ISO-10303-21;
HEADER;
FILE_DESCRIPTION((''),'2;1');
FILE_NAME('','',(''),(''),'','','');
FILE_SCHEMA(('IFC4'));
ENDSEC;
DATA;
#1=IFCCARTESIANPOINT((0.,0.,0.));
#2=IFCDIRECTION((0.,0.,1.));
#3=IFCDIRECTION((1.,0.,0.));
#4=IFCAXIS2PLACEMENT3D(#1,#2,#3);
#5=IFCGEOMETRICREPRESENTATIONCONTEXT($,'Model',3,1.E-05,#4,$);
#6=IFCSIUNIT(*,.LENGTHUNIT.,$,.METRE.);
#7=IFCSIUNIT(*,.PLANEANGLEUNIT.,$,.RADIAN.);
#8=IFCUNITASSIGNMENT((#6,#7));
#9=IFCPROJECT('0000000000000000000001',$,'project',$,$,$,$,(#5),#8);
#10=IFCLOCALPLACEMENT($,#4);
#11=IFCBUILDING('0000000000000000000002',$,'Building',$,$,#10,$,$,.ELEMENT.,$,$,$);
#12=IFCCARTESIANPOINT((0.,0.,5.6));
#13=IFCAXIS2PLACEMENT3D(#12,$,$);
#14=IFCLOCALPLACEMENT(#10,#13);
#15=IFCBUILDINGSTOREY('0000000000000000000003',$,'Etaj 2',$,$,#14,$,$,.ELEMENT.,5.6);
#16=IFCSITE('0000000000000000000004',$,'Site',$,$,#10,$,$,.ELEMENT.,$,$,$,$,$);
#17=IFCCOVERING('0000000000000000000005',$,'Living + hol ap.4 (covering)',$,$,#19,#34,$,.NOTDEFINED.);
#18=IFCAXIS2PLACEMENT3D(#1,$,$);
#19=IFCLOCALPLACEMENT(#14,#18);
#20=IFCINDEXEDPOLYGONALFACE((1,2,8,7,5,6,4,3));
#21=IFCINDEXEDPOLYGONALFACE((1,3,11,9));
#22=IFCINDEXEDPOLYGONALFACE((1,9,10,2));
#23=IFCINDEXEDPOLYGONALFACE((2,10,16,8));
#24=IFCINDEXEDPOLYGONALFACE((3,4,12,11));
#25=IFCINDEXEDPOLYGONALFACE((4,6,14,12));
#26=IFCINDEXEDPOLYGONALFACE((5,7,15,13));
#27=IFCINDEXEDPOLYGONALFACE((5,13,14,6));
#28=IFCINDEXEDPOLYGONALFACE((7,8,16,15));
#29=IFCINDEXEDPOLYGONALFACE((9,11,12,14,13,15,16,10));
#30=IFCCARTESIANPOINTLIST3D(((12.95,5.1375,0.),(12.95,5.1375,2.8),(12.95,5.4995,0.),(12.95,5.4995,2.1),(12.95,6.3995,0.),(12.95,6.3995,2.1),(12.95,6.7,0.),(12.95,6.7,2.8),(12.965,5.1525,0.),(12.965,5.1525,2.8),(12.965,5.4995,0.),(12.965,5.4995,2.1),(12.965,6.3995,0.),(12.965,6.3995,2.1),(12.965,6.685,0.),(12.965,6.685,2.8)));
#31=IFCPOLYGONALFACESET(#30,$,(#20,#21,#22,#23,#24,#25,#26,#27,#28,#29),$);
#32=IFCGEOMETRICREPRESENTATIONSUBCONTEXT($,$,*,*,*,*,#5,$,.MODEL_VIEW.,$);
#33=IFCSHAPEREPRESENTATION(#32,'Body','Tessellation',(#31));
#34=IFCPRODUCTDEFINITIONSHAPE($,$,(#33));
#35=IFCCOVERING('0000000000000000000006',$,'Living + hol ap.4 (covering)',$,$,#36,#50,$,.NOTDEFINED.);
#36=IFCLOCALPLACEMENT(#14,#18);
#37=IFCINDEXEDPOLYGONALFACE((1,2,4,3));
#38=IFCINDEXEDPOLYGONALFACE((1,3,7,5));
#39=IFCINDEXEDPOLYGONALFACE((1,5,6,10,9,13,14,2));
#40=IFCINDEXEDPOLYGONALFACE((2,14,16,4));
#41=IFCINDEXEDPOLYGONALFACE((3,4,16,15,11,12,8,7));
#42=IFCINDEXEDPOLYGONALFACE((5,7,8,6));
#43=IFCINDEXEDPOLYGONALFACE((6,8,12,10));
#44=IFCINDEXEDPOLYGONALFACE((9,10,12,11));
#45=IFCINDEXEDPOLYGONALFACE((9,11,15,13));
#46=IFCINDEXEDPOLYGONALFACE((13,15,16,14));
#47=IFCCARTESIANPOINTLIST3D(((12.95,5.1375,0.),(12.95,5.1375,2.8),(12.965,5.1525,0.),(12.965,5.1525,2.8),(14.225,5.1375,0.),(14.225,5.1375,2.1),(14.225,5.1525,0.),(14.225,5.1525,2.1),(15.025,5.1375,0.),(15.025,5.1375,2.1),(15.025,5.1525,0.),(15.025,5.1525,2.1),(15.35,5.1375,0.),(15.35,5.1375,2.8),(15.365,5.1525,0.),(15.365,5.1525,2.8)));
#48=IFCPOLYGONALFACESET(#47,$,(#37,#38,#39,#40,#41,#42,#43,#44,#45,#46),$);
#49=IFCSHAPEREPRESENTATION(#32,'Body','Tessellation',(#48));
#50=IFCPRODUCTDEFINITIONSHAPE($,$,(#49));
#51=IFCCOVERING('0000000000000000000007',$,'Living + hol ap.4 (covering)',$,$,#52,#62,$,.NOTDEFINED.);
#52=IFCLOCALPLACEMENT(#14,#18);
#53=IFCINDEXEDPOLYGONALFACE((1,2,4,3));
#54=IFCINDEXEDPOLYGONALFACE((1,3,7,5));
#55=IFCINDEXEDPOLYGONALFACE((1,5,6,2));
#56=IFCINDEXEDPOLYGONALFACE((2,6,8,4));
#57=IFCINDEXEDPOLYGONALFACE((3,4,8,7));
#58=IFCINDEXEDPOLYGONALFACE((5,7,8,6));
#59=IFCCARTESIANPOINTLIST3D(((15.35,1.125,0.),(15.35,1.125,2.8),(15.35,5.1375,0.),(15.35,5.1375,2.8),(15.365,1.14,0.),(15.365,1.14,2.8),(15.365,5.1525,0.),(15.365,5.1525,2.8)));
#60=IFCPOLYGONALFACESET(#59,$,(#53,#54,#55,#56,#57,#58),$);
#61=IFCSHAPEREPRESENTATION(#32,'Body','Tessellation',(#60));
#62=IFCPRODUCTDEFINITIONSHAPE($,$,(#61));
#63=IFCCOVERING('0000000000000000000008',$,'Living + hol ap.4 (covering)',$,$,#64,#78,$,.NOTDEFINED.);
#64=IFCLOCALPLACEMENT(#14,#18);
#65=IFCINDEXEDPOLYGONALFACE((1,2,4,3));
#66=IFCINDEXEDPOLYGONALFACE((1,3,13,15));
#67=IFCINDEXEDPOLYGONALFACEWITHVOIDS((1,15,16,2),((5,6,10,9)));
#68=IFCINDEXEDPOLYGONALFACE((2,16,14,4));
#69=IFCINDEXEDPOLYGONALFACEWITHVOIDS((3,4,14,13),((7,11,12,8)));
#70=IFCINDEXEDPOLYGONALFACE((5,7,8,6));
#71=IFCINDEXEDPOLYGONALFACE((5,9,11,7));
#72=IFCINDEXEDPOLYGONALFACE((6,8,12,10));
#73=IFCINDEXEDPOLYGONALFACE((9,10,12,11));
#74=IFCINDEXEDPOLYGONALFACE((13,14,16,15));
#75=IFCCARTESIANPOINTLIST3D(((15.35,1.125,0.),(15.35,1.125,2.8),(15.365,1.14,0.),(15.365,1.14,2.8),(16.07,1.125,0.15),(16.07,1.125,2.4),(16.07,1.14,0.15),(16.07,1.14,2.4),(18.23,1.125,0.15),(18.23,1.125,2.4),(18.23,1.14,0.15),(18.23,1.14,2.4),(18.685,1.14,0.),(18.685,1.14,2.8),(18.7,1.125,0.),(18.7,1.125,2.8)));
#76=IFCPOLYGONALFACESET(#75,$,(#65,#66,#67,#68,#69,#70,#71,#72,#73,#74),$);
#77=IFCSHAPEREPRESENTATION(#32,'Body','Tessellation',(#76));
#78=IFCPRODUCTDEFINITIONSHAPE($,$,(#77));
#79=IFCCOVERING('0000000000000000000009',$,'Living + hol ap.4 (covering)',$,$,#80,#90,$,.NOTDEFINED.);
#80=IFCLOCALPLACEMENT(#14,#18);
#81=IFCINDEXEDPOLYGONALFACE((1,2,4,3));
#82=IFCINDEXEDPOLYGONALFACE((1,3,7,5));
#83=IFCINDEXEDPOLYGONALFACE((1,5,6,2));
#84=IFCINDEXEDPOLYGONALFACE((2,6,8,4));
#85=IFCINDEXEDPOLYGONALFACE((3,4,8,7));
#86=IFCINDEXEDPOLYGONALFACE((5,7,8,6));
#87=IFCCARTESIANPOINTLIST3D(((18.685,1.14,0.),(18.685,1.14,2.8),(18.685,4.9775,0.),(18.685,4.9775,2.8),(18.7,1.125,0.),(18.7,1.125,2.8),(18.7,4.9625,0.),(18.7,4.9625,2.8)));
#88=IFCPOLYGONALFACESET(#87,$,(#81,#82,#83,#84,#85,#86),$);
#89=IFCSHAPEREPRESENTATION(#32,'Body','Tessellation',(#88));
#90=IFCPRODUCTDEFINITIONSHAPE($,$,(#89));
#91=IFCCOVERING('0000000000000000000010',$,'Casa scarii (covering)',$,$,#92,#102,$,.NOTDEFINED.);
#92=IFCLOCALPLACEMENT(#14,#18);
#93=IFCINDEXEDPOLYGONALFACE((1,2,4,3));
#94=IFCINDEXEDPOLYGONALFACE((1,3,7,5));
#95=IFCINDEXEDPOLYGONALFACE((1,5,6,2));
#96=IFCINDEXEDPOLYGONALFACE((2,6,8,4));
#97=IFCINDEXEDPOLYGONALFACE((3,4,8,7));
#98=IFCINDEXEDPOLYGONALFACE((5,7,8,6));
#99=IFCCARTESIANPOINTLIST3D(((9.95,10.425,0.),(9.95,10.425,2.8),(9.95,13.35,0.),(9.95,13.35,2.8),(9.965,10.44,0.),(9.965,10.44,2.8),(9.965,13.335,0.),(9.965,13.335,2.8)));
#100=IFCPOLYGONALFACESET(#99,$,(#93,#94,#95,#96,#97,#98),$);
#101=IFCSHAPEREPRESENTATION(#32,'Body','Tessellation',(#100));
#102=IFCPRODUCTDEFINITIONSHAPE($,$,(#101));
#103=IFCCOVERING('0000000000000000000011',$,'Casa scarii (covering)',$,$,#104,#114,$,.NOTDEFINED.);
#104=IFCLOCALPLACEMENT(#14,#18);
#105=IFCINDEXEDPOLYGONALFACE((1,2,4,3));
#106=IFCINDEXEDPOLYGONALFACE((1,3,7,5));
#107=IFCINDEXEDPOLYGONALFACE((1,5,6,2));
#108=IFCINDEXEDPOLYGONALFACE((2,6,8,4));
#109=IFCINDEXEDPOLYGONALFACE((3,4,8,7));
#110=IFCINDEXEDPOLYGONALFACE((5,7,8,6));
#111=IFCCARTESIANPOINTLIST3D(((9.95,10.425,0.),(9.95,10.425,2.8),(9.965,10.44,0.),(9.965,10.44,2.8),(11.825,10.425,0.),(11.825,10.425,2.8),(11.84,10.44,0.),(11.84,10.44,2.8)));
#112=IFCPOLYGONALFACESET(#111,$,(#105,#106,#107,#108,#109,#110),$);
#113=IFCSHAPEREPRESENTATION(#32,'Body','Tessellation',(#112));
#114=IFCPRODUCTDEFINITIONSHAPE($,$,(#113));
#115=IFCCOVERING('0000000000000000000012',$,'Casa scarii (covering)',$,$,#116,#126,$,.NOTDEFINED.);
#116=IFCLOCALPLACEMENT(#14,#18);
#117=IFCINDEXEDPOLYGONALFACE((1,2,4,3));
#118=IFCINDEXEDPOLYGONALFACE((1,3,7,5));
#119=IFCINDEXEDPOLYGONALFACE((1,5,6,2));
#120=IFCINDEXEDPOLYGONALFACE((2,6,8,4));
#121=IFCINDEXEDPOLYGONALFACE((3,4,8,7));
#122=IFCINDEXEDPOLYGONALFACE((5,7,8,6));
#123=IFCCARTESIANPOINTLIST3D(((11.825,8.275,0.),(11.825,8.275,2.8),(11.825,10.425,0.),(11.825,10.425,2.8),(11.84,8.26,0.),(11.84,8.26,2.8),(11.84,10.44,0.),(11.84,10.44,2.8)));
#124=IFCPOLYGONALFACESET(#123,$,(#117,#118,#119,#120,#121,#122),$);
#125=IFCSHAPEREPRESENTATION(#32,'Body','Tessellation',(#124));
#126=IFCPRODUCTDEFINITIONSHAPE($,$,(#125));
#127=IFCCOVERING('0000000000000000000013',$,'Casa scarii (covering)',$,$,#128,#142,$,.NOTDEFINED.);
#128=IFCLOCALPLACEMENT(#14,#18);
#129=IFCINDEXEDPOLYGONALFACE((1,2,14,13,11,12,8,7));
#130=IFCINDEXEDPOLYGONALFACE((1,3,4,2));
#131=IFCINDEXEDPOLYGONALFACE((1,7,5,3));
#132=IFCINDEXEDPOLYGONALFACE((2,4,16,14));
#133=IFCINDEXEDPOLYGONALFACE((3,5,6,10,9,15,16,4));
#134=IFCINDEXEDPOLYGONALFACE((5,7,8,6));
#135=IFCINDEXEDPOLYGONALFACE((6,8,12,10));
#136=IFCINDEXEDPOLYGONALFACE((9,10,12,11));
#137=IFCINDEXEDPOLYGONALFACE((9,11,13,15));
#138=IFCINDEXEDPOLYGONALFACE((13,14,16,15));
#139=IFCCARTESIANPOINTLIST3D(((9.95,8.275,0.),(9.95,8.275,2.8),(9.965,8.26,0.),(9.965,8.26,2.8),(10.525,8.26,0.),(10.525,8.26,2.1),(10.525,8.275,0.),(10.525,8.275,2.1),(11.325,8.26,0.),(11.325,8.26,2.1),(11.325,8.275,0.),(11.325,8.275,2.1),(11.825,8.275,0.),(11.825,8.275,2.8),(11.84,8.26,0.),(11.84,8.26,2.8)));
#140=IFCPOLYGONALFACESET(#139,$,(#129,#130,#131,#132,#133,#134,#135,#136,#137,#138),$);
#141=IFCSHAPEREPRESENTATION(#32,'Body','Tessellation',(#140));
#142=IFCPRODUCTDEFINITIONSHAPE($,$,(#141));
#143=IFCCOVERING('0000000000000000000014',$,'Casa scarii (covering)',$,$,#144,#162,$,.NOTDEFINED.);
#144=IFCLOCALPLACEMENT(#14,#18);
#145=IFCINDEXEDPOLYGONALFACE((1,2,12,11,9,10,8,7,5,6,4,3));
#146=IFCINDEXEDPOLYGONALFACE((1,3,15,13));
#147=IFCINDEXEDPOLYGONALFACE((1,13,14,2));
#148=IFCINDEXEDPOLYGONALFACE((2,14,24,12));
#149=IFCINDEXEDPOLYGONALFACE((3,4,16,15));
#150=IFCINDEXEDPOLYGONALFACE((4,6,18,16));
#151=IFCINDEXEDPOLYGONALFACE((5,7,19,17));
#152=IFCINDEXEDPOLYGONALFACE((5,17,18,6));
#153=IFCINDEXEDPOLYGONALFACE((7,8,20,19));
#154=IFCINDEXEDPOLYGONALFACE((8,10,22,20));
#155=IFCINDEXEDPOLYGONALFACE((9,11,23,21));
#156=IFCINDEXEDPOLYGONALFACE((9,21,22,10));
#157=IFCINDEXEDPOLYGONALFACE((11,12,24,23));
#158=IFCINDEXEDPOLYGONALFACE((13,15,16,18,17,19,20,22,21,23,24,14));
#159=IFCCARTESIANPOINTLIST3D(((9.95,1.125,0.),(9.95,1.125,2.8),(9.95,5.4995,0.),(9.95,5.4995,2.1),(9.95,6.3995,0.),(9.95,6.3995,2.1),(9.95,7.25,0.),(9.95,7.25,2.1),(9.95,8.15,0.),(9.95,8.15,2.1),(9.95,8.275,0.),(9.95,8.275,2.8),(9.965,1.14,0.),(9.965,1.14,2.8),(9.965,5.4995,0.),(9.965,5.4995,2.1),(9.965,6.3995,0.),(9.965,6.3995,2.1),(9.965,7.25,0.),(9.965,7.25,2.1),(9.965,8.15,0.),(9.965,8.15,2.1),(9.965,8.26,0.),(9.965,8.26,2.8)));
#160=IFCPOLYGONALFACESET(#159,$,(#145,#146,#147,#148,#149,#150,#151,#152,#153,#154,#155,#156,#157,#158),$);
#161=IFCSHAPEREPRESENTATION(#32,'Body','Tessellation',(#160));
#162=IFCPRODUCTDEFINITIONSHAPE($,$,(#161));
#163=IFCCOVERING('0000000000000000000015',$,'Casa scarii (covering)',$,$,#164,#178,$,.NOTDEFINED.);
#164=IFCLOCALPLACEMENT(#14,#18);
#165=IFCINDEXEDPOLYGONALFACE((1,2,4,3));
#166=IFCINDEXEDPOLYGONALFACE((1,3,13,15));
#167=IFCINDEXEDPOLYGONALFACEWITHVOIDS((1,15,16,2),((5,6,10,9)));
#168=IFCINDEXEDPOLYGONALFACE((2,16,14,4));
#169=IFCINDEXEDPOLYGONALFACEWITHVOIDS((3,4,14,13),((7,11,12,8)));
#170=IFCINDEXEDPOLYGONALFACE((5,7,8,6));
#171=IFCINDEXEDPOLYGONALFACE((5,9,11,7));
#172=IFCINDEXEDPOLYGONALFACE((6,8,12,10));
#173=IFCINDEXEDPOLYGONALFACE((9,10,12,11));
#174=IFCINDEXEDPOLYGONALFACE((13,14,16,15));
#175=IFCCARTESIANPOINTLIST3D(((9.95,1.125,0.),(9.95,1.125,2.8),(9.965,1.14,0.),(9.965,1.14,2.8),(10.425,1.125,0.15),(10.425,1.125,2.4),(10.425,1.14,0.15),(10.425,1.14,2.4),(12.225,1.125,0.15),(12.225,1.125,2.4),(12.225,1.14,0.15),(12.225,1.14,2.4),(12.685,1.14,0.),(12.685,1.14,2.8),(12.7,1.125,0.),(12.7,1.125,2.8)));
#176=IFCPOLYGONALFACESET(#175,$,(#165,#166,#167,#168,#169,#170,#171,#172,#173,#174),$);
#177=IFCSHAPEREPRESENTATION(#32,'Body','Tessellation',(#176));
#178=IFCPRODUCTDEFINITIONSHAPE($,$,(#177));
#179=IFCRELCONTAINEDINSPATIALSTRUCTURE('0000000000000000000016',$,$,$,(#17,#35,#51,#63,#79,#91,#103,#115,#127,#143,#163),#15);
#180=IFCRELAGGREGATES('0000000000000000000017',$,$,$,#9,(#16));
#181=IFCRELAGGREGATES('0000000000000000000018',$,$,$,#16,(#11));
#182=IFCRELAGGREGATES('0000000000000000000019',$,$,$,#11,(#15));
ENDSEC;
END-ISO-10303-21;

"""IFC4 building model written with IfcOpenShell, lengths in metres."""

from ifc_helpers import new_model, si_unit, frame, origin, origin_with_axes, origin_2d, place, context, subcontext, project, spatial, polyline, rectangle, outline, extrude, element, save


model = new_model("IFC4")

# Units and contexts
model_context = context("Model", 3, precision=1e-05, world=origin_with_axes())
sub_context = subcontext(model_context, None, None, "MODEL_VIEW")
ifc_project = project(units=[si_unit("LENGTHUNIT", "METRE"), si_unit("PLANEANGLEUNIT", "RADIAN")], contexts=[model_context])

# Site, building, storey
placement = place(None, origin_with_axes())
site = spatial("IfcSite", under=ifc_project, at=placement, Name="Site", CompositionType="ELEMENT")
building = spatial("IfcBuilding", under=site, at=placement, Name="Building", CompositionType="ELEMENT")
storey_placement = place(placement, frame((0.0, 0.0, 5.6)))
storey = spatial("IfcBuildingStorey", under=building, at=storey_placement, Name="Etaj 2", CompositionType="ELEMENT", Elevation=5.6)

# Coverings, openings
covering_1_placement = place(storey_placement, origin_with_axes())
covering_1 = element("IfcCovering", 1, at=covering_1_placement, inside=storey, Name="Living + hol ap.4 (covering)", PredefinedType="NOTDEFINED", context=sub_context, shape_type="SweptSolid", body=[
    extrude(outline(polyline([(12.95, 6.7), (12.95, 5.1375), (12.965, 5.1525), (12.965, 6.685), (12.95, 6.7)])), origin(), (0.0, 0.0, 1.0), 2.8),
])
opening_1_placement = place(covering_1_placement, frame((12.635, 5.9495, 0.0), z_axis=(1.0, 0.0, 0.0), x_axis=(0.0, 1.0, 0.0)))
element("IfcOpeningElement", 2, at=opening_1_placement, cuts=covering_1, PredefinedType="OPENING", context=sub_context, shape_type="SweptSolid", body=[
    extrude(rectangle(XDim=0.9, YDim=2.1, at=origin_2d()), frame((0.0, 1.05, 0.0)), (0.0, 0.0, 1.0), 0.38),
])
covering_2_placement = place(storey_placement, origin_with_axes())
covering_2 = element("IfcCovering", 3, at=covering_2_placement, inside=storey, Name="Living + hol ap.4 (covering)", PredefinedType="NOTDEFINED", context=sub_context, shape_type="SweptSolid", body=[
    extrude(outline(polyline([(12.95, 5.1375), (15.35, 5.1375), (15.365, 5.1525), (12.965, 5.1525), (12.95, 5.1375)])), origin(), (0.0, 0.0, 1.0), 2.8),
])
opening_2_placement = place(covering_2_placement, frame((14.625, 5.2025, 0.0), z_axis=(0.0, -1.0, 0.0), x_axis=(1.0, 0.0, 0.0)))
element("IfcOpeningElement", 4, at=opening_2_placement, cuts=covering_2, PredefinedType="OPENING", context=sub_context, shape_type="SweptSolid", body=[
    extrude(rectangle(XDim=0.8, YDim=2.1, at=origin_2d()), frame((0.0, 1.05, 0.0)), (0.0, 0.0, 1.0), 0.38),
])

# Covering
covering_3_placement = place(storey_placement, origin_with_axes())
element("IfcCovering", 5, at=covering_3_placement, inside=storey, Name="Living + hol ap.4 (covering)", PredefinedType="NOTDEFINED", context=sub_context, shape_type="SweptSolid", body=[
    extrude(outline(polyline([(15.35, 5.1375), (15.35, 1.125), (15.365, 1.14), (15.365, 5.1525), (15.35, 5.1375)])), origin(), (0.0, 0.0, 1.0), 2.8),
])

# Covering, opening
covering_4_placement = place(storey_placement, origin_with_axes())
covering_4 = element("IfcCovering", 6, at=covering_4_placement, inside=storey, Name="Living + hol ap.4 (covering)", PredefinedType="NOTDEFINED", context=sub_context, shape_type="SweptSolid", body=[
    extrude(outline(polyline([(15.35, 1.125), (18.7, 1.125), (18.685, 1.14), (15.365, 1.14), (15.35, 1.125)])), origin(), (0.0, 0.0, 1.0), 2.8),
])
opening_3_placement = place(covering_4_placement, frame((17.15, 1.19, 0.15), z_axis=(0.0, -1.0, 0.0), x_axis=(1.0, 0.0, 0.0)))
element("IfcOpeningElement", 7, at=opening_3_placement, cuts=covering_4, PredefinedType="OPENING", context=sub_context, shape_type="SweptSolid", body=[
    extrude(rectangle(XDim=2.16, YDim=2.25, at=origin_2d()), frame((0.0, 1.125, 0.0)), (0.0, 0.0, 1.0), 0.38),
])

# Coverings
covering_5_placement = place(storey_placement, origin_with_axes())
element("IfcCovering", 8, at=covering_5_placement, inside=storey, Name="Living + hol ap.4 (covering)", PredefinedType="NOTDEFINED", context=sub_context, shape_type="SweptSolid", body=[
    extrude(outline(polyline([(18.7, 1.125), (18.7, 4.9625), (18.685, 4.9775), (18.685, 1.14), (18.7, 1.125)])), origin(), (0.0, 0.0, 1.0), 2.8),
])
covering_6_placement = place(storey_placement, origin_with_axes())
element("IfcCovering", 9, at=covering_6_placement, inside=storey, Name="Casa scarii (covering)", PredefinedType="NOTDEFINED", context=sub_context, shape_type="SweptSolid", body=[
    extrude(outline(polyline([(9.95, 13.35), (9.95, 10.425), (9.965, 10.44), (9.965, 13.335), (9.95, 13.35)])), origin(), (0.0, 0.0, 1.0), 2.8),
])
covering_7_placement = place(storey_placement, origin_with_axes())
element("IfcCovering", 10, at=covering_7_placement, inside=storey, Name="Casa scarii (covering)", PredefinedType="NOTDEFINED", context=sub_context, shape_type="SweptSolid", body=[
    extrude(outline(polyline([(9.95, 10.425), (11.825, 10.425), (11.84, 10.44), (9.965, 10.44), (9.95, 10.425)])), origin(), (0.0, 0.0, 1.0), 2.8),
])
covering_8_placement = place(storey_placement, origin_with_axes())
element("IfcCovering", 11, at=covering_8_placement, inside=storey, Name="Casa scarii (covering)", PredefinedType="NOTDEFINED", context=sub_context, shape_type="SweptSolid", body=[
    extrude(outline(polyline([(11.825, 10.425), (11.825, 8.275), (11.84, 8.26), (11.84, 10.44), (11.825, 10.425)])), origin(), (0.0, 0.0, 1.0), 2.8),
])

# Covering, opening
covering_9_placement = place(storey_placement, origin_with_axes())
covering_9 = element("IfcCovering", 12, at=covering_9_placement, inside=storey, Name="Casa scarii (covering)", PredefinedType="NOTDEFINED", context=sub_context, shape_type="SweptSolid", body=[
    extrude(outline(polyline([(11.825, 8.275), (9.95, 8.275), (9.965, 8.26), (11.84, 8.26), (11.825, 8.275)])), origin(), (0.0, 0.0, 1.0), 2.8),
])
opening_4_placement = place(covering_9_placement, frame((10.925, 8.59, 0.0), z_axis=(0.0, -1.0, 0.0), x_axis=(1.0, 0.0, 0.0)))
element("IfcOpeningElement", 13, at=opening_4_placement, cuts=covering_9, PredefinedType="OPENING", context=sub_context, shape_type="SweptSolid", body=[
    extrude(rectangle(XDim=0.8, YDim=2.1, at=origin_2d()), frame((0.0, 1.05, 0.0)), (0.0, 0.0, 1.0), 0.38),
])

# Covering, openings
covering_10_placement = place(storey_placement, origin_with_axes())
covering_10 = element("IfcCovering", 14, at=covering_10_placement, inside=storey, Name="Casa scarii (covering)", PredefinedType="NOTDEFINED", context=sub_context, shape_type="SweptSolid", body=[
    extrude(outline(polyline([(9.95, 8.275), (9.95, 1.125), (9.965, 1.14), (9.965, 8.26), (9.95, 8.275)])), origin(), (0.0, 0.0, 1.0), 2.8),
])
opening_5_placement = place(covering_10_placement, frame((9.635, 5.9495, 0.0), z_axis=(1.0, 0.0, 0.0), x_axis=(0.0, 1.0, 0.0)))
element("IfcOpeningElement", 15, at=opening_5_placement, cuts=covering_10, PredefinedType="OPENING", context=sub_context, shape_type="SweptSolid", body=[
    extrude(rectangle(XDim=0.9, YDim=2.1, at=origin_2d()), frame((0.0, 1.05, 0.0)), (0.0, 0.0, 1.0), 0.38),
])
opening_6_placement = place(covering_10_placement, frame((9.635, 7.7, 0.0), z_axis=(1.0, 0.0, 0.0), x_axis=(0.0, 1.0, 0.0)))
element("IfcOpeningElement", 16, at=opening_6_placement, cuts=covering_10, PredefinedType="OPENING", context=sub_context, shape_type="SweptSolid", body=[
    extrude(rectangle(XDim=0.9, YDim=2.1, at=origin_2d()), frame((0.0, 1.05, 0.0)), (0.0, 0.0, 1.0), 0.38),
])

# Covering, opening
covering_11_placement = place(storey_placement, origin_with_axes())
covering_11 = element("IfcCovering", 17, at=covering_11_placement, inside=storey, Name="Casa scarii (covering)", PredefinedType="NOTDEFINED", context=sub_context, shape_type="SweptSolid", body=[
    extrude(outline(polyline([(9.95, 1.125), (12.7, 1.125), (12.685, 1.14), (9.965, 1.14), (9.95, 1.125)])), origin(), (0.0, 0.0, 1.0), 2.8),
])
opening_7_placement = place(covering_11_placement, frame((11.325, 1.19, 0.15), z_axis=(0.0, -1.0, 0.0), x_axis=(1.0, 0.0, 0.0)))
element("IfcOpeningElement", 18, at=opening_7_placement, cuts=covering_11, PredefinedType="OPENING", context=sub_context, shape_type="SweptSolid", body=[
    extrude(rectangle(XDim=1.8, YDim=2.25, at=origin_2d()), frame((0.0, 1.125, 0.0)), (0.0, 0.0, 1.0), 0.38),
])

save(model, "model.ifc")
